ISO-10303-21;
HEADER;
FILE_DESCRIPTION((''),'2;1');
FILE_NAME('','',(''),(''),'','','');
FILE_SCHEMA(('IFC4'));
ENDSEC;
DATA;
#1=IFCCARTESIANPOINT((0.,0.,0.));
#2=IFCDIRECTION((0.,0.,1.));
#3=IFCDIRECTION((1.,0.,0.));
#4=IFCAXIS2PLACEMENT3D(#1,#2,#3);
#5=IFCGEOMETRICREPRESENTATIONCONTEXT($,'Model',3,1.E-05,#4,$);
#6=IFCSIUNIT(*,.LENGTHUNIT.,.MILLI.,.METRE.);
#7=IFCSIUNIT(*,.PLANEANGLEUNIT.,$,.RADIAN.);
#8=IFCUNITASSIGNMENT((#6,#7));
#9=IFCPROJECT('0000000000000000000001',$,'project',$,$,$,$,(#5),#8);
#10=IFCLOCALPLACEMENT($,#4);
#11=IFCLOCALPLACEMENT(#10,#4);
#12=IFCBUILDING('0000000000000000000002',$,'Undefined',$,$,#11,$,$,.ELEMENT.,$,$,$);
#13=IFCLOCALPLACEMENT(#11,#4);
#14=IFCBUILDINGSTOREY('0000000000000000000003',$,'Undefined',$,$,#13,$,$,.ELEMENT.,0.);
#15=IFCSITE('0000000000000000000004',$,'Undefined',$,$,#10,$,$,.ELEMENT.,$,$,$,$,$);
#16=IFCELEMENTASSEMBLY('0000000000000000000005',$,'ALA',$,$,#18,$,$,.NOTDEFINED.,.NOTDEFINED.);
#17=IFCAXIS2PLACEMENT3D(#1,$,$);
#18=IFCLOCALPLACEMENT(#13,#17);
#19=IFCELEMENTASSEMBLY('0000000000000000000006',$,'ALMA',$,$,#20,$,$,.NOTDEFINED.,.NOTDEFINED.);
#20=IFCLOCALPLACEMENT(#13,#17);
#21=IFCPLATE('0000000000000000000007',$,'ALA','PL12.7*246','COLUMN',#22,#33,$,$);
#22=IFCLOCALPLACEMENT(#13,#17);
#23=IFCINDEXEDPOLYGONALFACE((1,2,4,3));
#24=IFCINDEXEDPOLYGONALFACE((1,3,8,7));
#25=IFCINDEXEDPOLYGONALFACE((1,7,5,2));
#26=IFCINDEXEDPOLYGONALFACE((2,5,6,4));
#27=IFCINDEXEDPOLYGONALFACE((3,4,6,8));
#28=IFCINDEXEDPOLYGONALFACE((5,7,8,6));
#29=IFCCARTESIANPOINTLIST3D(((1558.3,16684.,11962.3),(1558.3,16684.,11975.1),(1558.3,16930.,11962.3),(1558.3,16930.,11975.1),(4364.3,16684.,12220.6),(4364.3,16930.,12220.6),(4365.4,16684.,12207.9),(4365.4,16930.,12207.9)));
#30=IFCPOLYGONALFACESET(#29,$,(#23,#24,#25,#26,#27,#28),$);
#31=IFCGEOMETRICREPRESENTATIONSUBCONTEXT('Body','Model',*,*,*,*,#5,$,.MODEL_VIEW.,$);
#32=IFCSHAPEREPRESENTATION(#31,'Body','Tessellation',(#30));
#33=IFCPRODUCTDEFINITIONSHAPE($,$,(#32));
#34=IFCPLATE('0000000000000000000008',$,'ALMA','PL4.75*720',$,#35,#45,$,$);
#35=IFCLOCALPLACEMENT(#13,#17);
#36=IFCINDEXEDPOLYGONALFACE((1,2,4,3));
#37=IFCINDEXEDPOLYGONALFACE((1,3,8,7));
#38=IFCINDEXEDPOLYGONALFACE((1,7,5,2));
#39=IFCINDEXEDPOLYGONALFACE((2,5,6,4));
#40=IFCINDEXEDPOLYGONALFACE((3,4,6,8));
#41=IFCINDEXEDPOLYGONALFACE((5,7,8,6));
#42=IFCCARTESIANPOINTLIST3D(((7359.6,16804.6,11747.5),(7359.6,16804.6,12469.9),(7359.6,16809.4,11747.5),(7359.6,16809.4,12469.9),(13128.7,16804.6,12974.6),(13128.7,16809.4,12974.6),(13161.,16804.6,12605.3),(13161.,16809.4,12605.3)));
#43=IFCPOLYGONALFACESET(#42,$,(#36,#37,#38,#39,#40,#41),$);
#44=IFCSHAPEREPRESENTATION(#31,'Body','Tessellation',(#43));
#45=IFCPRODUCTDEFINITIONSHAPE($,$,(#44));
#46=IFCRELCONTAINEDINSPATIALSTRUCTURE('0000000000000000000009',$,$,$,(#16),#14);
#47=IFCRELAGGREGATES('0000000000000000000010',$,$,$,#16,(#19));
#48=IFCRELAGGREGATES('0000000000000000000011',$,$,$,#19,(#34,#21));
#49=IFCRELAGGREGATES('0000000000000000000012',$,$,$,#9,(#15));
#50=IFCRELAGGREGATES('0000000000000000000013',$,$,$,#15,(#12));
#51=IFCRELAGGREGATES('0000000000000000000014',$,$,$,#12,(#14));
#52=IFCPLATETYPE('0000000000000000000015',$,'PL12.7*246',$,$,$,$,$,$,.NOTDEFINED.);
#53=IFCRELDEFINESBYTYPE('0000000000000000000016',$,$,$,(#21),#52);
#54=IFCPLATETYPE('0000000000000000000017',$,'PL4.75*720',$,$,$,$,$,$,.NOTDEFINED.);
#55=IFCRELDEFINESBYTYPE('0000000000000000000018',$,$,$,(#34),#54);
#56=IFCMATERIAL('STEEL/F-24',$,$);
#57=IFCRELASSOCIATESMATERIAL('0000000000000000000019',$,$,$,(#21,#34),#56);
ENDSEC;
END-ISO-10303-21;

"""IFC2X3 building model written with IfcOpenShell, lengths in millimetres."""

from ifc_helpers import new_model, si_unit, frame, origin_with_axes, place, context, subcontext, project, spatial, polyline, outline, extrude, clip, halfspace, material, type_object, element, aggregate, save


model = new_model("IFC2X3")

# Units and contexts
model_context = context("Model", 3, precision=1e-05, world=origin_with_axes())
body_context = subcontext(model_context, "Body", "Model", "MODEL_VIEW")
ifc_project = project(units=[si_unit("LENGTHUNIT", "METRE", prefix="MILLI"), si_unit("PLANEANGLEUNIT", "RADIAN")], contexts=[model_context])

# Site, building, storey
site_placement = place(None, origin_with_axes())
site = spatial("IfcSite", under=ifc_project, at=site_placement, Name="Undefined", CompositionType="ELEMENT")
building_placement = place(site_placement, origin_with_axes())
building = spatial("IfcBuilding", under=site, at=building_placement, Name="Undefined", CompositionType="ELEMENT")
storey_placement = place(building_placement, origin_with_axes())
storey = spatial("IfcBuildingStorey", under=building, at=storey_placement, Name="Undefined", CompositionType="ELEMENT", Elevation=0.0)

# Shared definitions
ifc_material_1 = material(Name="STEEL/F-24")

# Element assembly
assembly_1_placement = place(storey_placement, origin_with_axes())
assembly_1 = element("IfcElementAssembly", 1, at=assembly_1_placement, inside=storey, Name="ALA", AssemblyPlace="NOTDEFINED", PredefinedType="NOTDEFINED")

# Element assembly
assembly_2_placement = place(assembly_1_placement, origin_with_axes())
assembly_2 = element("IfcElementAssembly", 2, at=assembly_2_placement, Name="ALMA", AssemblyPlace="NOTDEFINED", PredefinedType="NOTDEFINED")
aggregate(assembly_1, [assembly_2])

# Plates
plate_type_1 = type_object("IfcPlateType", Name="PL12.7*246", PredefinedType="NOTDEFINED")
plate_1_placement = place(assembly_2_placement, frame((4364.9, 16807.0, 12214.3), z_axis=(-0.087156, 0.0, 0.996195), x_axis=(-0.996195, 0.0, -0.087155)))
plate_1 = element("IfcPlate", 3, at=plate_1_placement, type_object=plate_type_1, material=ifc_material_1, Name="ALA", Description="PL12.7*246", ObjectType="COLUMN", context=body_context, shape_type="Clipping", body=[
    clip(extrude(outline(polyline([(0.0, -123.0), (0.0, 123.0), (2817.8, 123.0), (2817.8, -123.0), (0.0, -123.0)])), frame((0.0, 0.0, -6.3), z_axis=(0.0, 0.0, 1.0), x_axis=(1.0, 0.0, 0.0)), (0.0, 0.0, 1.0), 12.7), halfspace(frame((2817.3, 0.0, 0.0), z_axis=(-0.996195, 0.0, -0.087155), x_axis=(0.0, 1.0, 0.0)), True)),
])
plate_type_2 = type_object("IfcPlateType", Name="PL4.75*720", PredefinedType="NOTDEFINED")
plate_2_placement = place(assembly_2_placement, frame((7359.6, 16807.0, 12469.9), z_axis=(0.0, -1.0, 0.0), x_axis=(0.000003, 0.0, -1.0)))
plate_2 = element("IfcPlate", 4, at=plate_2_placement, type_object=plate_type_2, material=ifc_material_1, Name="ALMA", Description="PL4.75*720", context=body_context, shape_type="SweptSolid", body=[
    extrude(outline(polyline([(0.0, 0.0), (722.4, 0.0), (-135.4, 5801.3), (-504.7, 5769.0), (0.0, 0.0)])), frame((0.0, 0.0, -2.4), z_axis=(0.0, 0.0, 1.0), x_axis=(1.0, 0.0, 0.0)), (0.0, 0.0, 1.0), 4.8),
])
aggregate(assembly_2, [plate_2, plate_1])

save(model, "model.ifc")
